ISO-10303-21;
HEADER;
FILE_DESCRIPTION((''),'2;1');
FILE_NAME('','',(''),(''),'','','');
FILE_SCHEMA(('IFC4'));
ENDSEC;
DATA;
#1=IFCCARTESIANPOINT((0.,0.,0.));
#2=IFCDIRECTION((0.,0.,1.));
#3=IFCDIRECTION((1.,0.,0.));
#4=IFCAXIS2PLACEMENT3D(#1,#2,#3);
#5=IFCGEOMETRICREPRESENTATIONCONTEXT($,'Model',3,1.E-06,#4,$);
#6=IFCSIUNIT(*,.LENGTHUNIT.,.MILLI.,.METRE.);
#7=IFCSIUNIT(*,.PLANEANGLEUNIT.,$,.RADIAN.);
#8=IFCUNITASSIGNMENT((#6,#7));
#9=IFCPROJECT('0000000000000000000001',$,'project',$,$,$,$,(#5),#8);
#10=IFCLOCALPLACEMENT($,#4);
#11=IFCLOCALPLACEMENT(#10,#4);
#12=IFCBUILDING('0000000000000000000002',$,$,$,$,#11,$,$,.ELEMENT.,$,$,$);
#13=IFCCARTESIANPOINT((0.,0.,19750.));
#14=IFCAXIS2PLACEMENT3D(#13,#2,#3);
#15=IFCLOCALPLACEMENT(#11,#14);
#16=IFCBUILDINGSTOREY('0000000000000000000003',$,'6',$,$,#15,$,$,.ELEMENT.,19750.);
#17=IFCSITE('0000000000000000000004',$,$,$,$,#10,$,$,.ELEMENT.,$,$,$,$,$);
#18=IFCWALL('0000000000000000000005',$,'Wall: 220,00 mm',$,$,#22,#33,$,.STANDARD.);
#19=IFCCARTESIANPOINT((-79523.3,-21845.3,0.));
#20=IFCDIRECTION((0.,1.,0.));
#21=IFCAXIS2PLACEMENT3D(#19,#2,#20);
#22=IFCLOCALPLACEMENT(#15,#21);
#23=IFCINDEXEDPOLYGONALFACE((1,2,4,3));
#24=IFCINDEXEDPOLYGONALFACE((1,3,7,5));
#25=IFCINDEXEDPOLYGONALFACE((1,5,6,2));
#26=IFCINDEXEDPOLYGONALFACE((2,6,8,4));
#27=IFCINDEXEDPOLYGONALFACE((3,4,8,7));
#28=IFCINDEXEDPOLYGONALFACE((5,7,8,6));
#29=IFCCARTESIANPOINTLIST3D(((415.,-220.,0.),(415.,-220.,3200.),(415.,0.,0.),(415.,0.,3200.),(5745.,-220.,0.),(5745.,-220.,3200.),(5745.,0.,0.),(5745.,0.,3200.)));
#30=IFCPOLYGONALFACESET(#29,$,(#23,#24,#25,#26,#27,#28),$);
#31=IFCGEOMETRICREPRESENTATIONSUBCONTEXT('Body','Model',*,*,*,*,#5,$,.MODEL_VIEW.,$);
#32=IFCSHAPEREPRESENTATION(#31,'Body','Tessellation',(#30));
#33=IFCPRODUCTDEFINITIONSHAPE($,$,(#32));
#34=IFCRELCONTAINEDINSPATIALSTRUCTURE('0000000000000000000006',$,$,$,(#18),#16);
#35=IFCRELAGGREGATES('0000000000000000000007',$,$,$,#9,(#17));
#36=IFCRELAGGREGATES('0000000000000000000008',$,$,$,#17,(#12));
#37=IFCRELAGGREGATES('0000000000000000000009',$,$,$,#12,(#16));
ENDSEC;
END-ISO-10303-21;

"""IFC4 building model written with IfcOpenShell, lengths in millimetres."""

from ifc_helpers import new_model, si_unit, frame, origin_with_axes, place, context, subcontext, project, spatial, line, indexed_curve, outline, extrude, element, save


model = new_model("IFC4")

# Units and contexts
model_context = context("Model", 3, precision=1e-06, world=origin_with_axes())
body_context = subcontext(model_context, "Body", "Model", "MODEL_VIEW")
ifc_project = project(units=[si_unit("LENGTHUNIT", "METRE", prefix="MILLI"), si_unit("PLANEANGLEUNIT", "RADIAN")], contexts=[model_context])

# Site, building, storey
site_placement = place(None, origin_with_axes())
site = spatial("IfcSite", under=ifc_project, at=site_placement, CompositionType="ELEMENT")
building_placement = place(site_placement, origin_with_axes())
building = spatial("IfcBuilding", under=site, at=building_placement, CompositionType="ELEMENT")
storey_placement = place(building_placement, frame((0.0, 0.0, 19750.0), z_axis=(0.0, 0.0, 1.0), x_axis=(1.0, 0.0, 0.0)))
storey = spatial("IfcBuildingStorey", under=building, at=storey_placement, Name="6", CompositionType="ELEMENT", Elevation=19750.0)

# Wall
wall_1_placement = place(storey_placement, frame((-79523.3, -21845.3, 0.0), z_axis=(0.0, 0.0, 1.0), x_axis=(0.0, 1.0, 0.0)))
element("IfcWall", 1, at=wall_1_placement, inside=storey, Name="Wall: 220,00 mm", PredefinedType="STANDARD", context=body_context, shape_type="SweptSolid", body=[
    extrude(outline(indexed_curve([(415.0, -220.0), (5745.0, -220.0), (5745.0, 0.0), (415.0, 0.0)], segments=[line(1, 2), line(2, 3), line(3, 4), line(4, 1)])), origin_with_axes(), (0.0, 0.0, 1.0), 3200.0),
])

save(model, "model.ifc")
